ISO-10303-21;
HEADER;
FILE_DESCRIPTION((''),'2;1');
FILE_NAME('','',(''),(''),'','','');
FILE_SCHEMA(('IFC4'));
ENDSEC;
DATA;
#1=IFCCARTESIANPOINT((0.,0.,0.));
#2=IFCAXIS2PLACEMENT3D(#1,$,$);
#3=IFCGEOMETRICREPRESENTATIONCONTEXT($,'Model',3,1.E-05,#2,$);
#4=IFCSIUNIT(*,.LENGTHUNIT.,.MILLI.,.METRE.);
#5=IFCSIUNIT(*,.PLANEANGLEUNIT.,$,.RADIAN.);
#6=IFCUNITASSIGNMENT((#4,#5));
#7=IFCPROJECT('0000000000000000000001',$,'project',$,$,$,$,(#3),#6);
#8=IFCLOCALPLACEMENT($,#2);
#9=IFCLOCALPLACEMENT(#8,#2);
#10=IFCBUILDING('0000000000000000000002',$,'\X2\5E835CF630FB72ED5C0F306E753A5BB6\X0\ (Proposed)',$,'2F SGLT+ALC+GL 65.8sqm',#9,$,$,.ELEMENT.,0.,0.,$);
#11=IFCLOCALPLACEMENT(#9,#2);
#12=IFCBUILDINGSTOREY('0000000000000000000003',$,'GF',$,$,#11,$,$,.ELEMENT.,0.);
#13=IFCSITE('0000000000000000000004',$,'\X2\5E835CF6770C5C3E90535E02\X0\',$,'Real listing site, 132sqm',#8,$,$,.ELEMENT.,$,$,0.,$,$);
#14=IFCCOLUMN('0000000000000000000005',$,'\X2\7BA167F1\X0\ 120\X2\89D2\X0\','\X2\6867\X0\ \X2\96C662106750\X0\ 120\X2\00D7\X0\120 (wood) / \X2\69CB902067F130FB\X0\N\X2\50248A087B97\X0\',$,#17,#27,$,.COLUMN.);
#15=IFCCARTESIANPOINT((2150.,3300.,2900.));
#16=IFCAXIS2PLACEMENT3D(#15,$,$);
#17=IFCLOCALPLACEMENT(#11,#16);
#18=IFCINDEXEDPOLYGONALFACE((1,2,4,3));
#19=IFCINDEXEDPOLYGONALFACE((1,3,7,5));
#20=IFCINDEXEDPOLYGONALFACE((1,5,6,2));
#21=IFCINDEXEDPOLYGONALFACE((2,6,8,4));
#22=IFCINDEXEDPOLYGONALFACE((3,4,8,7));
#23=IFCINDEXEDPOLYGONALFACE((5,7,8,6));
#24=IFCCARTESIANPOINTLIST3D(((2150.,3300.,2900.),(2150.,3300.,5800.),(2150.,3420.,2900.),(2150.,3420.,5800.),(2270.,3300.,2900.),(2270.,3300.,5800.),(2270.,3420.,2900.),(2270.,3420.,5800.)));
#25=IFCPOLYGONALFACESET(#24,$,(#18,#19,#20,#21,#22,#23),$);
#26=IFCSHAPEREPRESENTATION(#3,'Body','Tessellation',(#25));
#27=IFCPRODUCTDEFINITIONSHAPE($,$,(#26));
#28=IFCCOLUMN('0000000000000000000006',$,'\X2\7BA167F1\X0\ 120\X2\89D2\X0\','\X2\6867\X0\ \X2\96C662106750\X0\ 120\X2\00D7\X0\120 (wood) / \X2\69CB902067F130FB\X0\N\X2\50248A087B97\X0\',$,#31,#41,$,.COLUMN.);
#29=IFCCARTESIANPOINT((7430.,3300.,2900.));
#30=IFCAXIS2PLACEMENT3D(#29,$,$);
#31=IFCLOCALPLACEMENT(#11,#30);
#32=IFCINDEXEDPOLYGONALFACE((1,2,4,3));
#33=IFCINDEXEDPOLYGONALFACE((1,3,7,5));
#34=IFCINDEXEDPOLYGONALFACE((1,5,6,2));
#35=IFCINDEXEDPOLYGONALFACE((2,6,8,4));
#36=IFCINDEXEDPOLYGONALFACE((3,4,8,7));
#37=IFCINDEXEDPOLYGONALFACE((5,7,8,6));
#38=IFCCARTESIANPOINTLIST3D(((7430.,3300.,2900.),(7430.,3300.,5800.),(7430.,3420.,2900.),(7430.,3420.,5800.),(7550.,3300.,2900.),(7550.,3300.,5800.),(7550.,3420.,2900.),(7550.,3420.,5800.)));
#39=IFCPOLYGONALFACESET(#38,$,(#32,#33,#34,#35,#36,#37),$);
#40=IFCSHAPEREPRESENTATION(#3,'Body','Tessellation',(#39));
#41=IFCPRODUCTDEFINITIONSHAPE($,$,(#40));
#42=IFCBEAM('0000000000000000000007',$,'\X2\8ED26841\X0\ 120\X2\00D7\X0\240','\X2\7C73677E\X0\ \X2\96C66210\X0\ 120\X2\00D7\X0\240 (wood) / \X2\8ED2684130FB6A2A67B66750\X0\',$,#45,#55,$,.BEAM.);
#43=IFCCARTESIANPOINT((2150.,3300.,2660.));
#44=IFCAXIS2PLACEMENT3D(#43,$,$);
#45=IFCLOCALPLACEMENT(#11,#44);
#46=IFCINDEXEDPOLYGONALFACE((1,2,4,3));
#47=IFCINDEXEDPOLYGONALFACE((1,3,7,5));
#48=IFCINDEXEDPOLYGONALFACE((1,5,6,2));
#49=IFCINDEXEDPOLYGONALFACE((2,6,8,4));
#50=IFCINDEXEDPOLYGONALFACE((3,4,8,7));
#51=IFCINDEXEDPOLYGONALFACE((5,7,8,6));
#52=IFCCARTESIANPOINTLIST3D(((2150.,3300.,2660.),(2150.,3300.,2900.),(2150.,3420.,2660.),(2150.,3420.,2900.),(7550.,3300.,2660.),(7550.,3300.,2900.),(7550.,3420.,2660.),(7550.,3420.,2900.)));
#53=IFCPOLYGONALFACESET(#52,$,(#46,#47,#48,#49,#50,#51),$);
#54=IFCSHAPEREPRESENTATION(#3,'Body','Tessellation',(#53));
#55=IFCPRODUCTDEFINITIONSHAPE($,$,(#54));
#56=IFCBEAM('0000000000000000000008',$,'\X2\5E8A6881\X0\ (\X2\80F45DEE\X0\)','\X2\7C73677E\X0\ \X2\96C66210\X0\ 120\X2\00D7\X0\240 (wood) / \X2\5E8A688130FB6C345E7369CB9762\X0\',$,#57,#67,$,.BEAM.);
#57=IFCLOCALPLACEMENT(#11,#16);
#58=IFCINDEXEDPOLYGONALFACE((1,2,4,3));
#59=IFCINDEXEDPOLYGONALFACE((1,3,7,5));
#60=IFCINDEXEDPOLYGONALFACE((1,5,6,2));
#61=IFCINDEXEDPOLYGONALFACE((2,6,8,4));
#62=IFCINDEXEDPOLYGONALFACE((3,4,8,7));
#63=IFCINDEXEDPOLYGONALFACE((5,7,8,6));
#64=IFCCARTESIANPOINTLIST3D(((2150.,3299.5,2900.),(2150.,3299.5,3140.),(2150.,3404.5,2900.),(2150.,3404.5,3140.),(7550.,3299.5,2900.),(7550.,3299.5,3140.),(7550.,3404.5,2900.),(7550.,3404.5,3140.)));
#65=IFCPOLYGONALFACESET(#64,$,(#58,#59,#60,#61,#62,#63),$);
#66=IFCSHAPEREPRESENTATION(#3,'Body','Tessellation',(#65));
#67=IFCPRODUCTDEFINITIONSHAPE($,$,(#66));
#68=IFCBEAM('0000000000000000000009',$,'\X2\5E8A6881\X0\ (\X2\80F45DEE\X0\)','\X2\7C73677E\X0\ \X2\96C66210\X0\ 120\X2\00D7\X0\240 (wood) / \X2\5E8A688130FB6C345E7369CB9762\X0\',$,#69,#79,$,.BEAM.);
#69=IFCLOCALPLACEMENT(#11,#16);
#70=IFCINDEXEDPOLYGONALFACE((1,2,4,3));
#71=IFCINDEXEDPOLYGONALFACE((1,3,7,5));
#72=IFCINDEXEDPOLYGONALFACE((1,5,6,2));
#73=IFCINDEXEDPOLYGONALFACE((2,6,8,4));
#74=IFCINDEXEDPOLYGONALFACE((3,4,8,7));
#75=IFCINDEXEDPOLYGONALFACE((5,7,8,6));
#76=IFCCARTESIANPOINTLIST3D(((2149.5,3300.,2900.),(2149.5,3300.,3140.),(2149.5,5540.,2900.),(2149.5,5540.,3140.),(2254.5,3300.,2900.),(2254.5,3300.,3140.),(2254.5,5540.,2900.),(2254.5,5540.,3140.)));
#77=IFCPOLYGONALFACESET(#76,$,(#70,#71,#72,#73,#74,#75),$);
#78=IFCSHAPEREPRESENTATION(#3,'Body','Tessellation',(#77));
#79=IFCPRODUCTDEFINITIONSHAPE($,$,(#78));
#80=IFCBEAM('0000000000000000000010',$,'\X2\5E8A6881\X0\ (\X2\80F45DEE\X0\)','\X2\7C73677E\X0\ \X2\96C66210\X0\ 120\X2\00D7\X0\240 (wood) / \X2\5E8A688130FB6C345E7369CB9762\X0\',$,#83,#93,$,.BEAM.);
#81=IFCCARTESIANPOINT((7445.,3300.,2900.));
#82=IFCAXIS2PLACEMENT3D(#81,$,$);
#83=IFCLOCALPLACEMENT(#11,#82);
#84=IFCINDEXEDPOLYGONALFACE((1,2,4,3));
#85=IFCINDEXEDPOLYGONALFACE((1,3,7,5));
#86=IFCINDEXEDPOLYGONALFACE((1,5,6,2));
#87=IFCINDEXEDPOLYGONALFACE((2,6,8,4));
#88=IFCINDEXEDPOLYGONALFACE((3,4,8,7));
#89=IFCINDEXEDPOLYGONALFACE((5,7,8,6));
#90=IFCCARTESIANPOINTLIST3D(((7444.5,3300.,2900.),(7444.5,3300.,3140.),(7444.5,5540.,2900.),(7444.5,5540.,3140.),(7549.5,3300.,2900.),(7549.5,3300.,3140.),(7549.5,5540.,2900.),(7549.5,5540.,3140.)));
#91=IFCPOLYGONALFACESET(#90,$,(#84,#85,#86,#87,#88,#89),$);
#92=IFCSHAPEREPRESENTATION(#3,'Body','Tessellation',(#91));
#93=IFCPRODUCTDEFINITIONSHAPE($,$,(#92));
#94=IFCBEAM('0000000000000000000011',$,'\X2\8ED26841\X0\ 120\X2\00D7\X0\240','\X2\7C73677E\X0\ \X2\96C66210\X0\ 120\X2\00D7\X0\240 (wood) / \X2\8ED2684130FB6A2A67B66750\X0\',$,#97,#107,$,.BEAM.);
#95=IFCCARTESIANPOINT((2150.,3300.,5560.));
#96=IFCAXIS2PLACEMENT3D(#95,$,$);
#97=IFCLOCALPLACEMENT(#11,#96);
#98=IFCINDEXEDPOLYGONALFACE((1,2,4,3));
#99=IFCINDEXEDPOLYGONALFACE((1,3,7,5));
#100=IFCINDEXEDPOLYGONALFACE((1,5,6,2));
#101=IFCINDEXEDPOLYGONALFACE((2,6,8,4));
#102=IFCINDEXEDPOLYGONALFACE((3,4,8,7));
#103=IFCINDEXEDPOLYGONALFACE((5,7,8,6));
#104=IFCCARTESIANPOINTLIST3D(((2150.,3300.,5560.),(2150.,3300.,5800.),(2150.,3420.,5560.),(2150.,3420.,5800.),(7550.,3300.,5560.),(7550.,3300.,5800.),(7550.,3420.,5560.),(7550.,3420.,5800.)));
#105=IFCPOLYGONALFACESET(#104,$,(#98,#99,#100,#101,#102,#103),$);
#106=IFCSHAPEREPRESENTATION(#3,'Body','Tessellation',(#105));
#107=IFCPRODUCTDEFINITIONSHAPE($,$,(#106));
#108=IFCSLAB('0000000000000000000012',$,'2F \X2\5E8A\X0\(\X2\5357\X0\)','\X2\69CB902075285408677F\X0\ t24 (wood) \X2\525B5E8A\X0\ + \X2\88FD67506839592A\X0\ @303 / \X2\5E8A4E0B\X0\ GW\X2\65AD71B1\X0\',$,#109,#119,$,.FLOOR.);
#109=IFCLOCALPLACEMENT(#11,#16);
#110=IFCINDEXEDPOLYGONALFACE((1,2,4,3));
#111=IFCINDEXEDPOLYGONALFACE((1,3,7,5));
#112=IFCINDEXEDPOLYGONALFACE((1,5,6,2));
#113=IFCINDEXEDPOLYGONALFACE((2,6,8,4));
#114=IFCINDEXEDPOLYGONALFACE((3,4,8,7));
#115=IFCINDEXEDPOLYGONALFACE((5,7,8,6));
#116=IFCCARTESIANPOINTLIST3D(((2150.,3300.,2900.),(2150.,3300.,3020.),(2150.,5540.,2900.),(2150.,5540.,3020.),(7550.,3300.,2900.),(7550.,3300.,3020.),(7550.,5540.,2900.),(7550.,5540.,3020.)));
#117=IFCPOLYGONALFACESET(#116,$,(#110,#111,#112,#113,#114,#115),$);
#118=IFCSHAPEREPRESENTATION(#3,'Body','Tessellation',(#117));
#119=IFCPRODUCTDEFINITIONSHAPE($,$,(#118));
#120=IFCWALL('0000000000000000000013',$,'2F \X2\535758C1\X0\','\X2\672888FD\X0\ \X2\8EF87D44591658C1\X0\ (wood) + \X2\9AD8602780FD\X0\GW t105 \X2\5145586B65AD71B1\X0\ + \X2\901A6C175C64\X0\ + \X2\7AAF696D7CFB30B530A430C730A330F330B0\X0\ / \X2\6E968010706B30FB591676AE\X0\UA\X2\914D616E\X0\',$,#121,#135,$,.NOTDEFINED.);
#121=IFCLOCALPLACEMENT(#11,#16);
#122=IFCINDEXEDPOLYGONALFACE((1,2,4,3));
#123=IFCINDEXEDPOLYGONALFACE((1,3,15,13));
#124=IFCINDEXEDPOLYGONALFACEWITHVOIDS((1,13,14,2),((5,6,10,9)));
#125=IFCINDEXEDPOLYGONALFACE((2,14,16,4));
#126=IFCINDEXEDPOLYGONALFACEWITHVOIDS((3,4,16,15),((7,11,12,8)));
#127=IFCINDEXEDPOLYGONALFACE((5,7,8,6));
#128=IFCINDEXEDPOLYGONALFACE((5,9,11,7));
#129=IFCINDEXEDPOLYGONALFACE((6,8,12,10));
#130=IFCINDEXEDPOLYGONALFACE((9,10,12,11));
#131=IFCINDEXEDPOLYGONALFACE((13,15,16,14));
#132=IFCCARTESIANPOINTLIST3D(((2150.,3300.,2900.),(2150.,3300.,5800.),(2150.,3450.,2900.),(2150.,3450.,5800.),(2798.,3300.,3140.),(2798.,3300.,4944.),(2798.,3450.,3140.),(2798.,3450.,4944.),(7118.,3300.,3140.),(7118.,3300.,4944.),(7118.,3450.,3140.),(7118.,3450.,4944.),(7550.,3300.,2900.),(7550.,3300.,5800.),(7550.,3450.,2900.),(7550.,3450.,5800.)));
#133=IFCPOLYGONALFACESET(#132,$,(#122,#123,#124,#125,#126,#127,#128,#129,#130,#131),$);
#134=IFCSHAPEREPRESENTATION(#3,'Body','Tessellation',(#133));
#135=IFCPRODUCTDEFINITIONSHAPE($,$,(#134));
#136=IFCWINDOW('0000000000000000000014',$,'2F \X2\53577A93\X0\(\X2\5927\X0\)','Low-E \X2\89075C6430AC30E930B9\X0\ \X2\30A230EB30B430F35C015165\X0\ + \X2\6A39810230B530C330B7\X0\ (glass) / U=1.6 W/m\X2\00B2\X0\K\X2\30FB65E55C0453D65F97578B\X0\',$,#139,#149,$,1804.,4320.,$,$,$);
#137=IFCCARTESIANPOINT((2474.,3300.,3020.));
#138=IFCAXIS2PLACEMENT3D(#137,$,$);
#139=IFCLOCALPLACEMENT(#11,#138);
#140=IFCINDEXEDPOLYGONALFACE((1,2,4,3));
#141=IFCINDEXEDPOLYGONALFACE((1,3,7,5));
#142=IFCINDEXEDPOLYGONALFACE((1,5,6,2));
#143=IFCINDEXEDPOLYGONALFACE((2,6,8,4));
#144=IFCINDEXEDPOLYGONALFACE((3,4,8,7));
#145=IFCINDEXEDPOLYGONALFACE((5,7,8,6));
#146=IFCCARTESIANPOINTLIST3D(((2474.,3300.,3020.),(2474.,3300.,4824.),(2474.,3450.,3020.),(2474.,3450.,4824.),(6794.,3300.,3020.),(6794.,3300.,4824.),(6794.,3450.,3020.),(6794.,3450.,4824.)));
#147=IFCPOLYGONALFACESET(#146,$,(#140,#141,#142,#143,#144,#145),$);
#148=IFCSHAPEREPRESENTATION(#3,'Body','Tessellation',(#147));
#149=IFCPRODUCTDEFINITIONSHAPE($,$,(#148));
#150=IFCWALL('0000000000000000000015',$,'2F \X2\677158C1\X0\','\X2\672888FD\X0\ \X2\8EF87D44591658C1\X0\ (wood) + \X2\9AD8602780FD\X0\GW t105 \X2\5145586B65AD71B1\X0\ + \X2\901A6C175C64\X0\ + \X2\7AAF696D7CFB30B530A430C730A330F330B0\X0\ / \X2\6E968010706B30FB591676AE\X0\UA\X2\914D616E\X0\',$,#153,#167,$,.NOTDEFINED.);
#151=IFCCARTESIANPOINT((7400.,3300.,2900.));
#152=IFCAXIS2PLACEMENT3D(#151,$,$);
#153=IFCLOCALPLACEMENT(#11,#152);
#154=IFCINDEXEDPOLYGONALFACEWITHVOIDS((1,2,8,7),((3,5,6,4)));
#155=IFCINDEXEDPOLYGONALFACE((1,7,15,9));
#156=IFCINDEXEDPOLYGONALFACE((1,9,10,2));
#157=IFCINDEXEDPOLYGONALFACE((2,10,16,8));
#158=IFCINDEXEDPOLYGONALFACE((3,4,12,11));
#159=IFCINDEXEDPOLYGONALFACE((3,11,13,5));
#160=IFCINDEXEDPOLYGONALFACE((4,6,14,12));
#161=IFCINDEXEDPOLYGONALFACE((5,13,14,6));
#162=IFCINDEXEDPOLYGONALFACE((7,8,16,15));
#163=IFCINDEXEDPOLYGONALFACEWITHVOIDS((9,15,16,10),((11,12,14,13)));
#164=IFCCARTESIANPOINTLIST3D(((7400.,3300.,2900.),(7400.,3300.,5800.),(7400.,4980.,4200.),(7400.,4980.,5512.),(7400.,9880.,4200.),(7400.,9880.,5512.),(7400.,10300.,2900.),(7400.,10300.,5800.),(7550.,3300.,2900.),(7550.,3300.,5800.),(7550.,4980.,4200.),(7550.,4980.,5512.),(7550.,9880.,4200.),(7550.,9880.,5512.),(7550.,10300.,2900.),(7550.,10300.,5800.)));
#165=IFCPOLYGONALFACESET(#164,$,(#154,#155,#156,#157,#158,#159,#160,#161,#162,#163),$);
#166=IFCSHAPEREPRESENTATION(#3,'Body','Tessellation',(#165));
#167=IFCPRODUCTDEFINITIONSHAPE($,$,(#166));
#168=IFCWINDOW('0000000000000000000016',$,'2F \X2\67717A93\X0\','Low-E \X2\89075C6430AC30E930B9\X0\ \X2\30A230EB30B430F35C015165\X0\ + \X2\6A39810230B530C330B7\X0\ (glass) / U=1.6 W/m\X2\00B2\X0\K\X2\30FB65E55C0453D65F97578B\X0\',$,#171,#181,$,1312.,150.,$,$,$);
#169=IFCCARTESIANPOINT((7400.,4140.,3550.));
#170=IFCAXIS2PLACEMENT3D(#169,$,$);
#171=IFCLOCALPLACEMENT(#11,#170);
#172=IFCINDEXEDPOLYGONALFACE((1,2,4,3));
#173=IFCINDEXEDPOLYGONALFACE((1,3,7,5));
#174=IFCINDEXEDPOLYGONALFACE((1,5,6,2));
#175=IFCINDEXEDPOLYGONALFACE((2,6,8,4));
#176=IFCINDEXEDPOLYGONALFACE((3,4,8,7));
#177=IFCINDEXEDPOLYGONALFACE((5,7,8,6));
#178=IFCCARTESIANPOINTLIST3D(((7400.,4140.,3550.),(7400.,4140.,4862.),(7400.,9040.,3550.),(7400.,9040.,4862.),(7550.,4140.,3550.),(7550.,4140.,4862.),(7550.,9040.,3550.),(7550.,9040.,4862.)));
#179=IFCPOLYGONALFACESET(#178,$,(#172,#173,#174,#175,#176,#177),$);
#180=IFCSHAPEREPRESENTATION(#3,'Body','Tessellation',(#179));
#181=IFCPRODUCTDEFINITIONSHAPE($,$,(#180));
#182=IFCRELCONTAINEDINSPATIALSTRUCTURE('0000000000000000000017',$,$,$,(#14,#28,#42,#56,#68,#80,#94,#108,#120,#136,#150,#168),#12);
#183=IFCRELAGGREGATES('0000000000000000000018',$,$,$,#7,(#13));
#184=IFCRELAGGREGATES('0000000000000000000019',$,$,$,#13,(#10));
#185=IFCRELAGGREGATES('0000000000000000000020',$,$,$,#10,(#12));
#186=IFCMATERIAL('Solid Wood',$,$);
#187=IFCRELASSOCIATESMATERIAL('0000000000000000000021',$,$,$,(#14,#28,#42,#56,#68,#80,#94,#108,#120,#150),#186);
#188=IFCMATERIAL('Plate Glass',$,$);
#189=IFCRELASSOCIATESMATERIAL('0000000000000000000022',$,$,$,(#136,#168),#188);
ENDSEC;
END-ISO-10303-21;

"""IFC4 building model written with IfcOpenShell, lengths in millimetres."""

from ifc_helpers import new_model, si_unit, frame, frame_2d, origin, place, context, project, spatial, rectangle, extrude, material, element, fill, save


model = new_model("IFC4")

# Units and contexts
model_context = context("Model", 3, precision=1e-05, world=origin())
ifc_project = project(units=[si_unit("LENGTHUNIT", "METRE", prefix="MILLI"), si_unit("PLANEANGLEUNIT", "RADIAN")], contexts=[model_context])

# Site, building, storey
site_placement = place(None, origin())
site = spatial("IfcSite", under=ifc_project, at=site_placement, Name="広島県尾道市", ObjectType="Real listing site, 132sqm", CompositionType="ELEMENT", RefElevation=0.0)
building_placement = place(site_placement, origin())
building = spatial("IfcBuilding", under=site, at=building_placement, Name="広島・狭小の町家 (Proposed)", ObjectType="2F SGLT+ALC+GL 65.8sqm", CompositionType="ELEMENT", ElevationOfRefHeight=0.0, ElevationOfTerrain=0.0)
storey_placement = place(building_placement, origin())
storey = spatial("IfcBuildingStorey", under=building, at=storey_placement, Name="GF", CompositionType="ELEMENT", Elevation=0.0)

# Columns
ifc_material_1 = material(Name="Solid Wood")
column_1_placement = place(storey_placement, frame((2150.0, 3300.0, 2900.0)))
element("IfcColumn", 1, at=column_1_placement, inside=storey, material=ifc_material_1, Name="管柱 120角", Description="桧 集成材 120×120 (wood) / 構造柱・N値計算", PredefinedType="COLUMN", context=model_context, shape_type="SweptSolid", body=[
    extrude(rectangle(XDim=120.0, YDim=120.0, at=frame_2d((60.0, 60.0))), frame((2150.0, 3300.0, 2900.0)), (0.0, 0.0, 1.0), 2900.0),
])
column_2_placement = place(storey_placement, frame((7430.0, 3300.0, 2900.0)))
element("IfcColumn", 2, at=column_2_placement, inside=storey, material=ifc_material_1, Name="管柱 120角", Description="桧 集成材 120×120 (wood) / 構造柱・N値計算", PredefinedType="COLUMN", context=model_context, shape_type="SweptSolid", body=[
    extrude(rectangle(XDim=120.0, YDim=120.0, at=frame_2d((60.0, 60.0))), frame((7430.0, 3300.0, 2900.0)), (0.0, 0.0, 1.0), 2900.0),
])

# Beams
beam_1_placement = place(storey_placement, frame((2150.0, 3300.0, 2660.0)))
element("IfcBeam", 3, at=beam_1_placement, inside=storey, material=ifc_material_1, Name="軒桁 120×240", Description="米松 集成 120×240 (wood) / 軒桁・横架材", PredefinedType="BEAM", context=model_context, shape_type="SweptSolid", body=[
    extrude(rectangle(XDim=5400.0, YDim=120.0, at=frame_2d((2700.0, 60.0))), frame((2150.0, 3300.0, 2660.0)), (0.0, 0.0, 1.0), 240.0),
])
beam_2_placement = place(storey_placement, frame((2150.0, 3300.0, 2900.0)))
element("IfcBeam", 4, at=beam_2_placement, inside=storey, material=ifc_material_1, Name="床梁 (胴差)", Description="米松 集成 120×240 (wood) / 床梁・水平構面", PredefinedType="BEAM", context=model_context, shape_type="SweptSolid", body=[
    extrude(rectangle(XDim=5400.0, YDim=105.0, at=frame_2d((2700.0, 52.0))), frame((2150.0, 3300.0, 2900.0)), (0.0, 0.0, 1.0), 240.0),
])
beam_3_placement = place(storey_placement, frame((2150.0, 3300.0, 2900.0)))
element("IfcBeam", 5, at=beam_3_placement, inside=storey, material=ifc_material_1, Name="床梁 (胴差)", Description="米松 集成 120×240 (wood) / 床梁・水平構面", PredefinedType="BEAM", context=model_context, shape_type="SweptSolid", body=[
    extrude(rectangle(XDim=105.0, YDim=2240.0, at=frame_2d((52.0, 1120.0))), frame((2150.0, 3300.0, 2900.0)), (0.0, 0.0, 1.0), 240.0),
])
beam_4_placement = place(storey_placement, frame((7445.0, 3300.0, 2900.0)))
element("IfcBeam", 6, at=beam_4_placement, inside=storey, material=ifc_material_1, Name="床梁 (胴差)", Description="米松 集成 120×240 (wood) / 床梁・水平構面", PredefinedType="BEAM", context=model_context, shape_type="SweptSolid", body=[
    extrude(rectangle(XDim=105.0, YDim=2240.0, at=frame_2d((52.0, 1120.0))), frame((7445.0, 3300.0, 2900.0)), (0.0, 0.0, 1.0), 240.0),
])
beam_5_placement = place(storey_placement, frame((2150.0, 3300.0, 5560.0)))
element("IfcBeam", 7, at=beam_5_placement, inside=storey, material=ifc_material_1, Name="軒桁 120×240", Description="米松 集成 120×240 (wood) / 軒桁・横架材", PredefinedType="BEAM", context=model_context, shape_type="SweptSolid", body=[
    extrude(rectangle(XDim=5400.0, YDim=120.0, at=frame_2d((2700.0, 60.0))), frame((2150.0, 3300.0, 5560.0)), (0.0, 0.0, 1.0), 240.0),
])

# Slab
slab_placement = place(storey_placement, frame((2150.0, 3300.0, 2900.0)))
element("IfcSlab", 8, at=slab_placement, inside=storey, material=ifc_material_1, Name="2F 床(南)", Description="構造用合板 t24 (wood) 剛床 + 製材根太 @303 / 床下 GW断熱", PredefinedType="FLOOR", context=model_context, shape_type="SweptSolid", body=[
    extrude(rectangle(XDim=5400.0, YDim=2240.0, at=frame_2d((2700.0, 1120.0))), frame((2150.0, 3300.0, 2900.0)), (0.0, 0.0, 1.0), 120.0),
])

# Walls, openings, windows
wall_1_placement = place(storey_placement, frame((2150.0, 3300.0, 2900.0)))
wall_1 = element("IfcWall", 9, at=wall_1_placement, inside=storey, material=ifc_material_1, Name="2F 南壁", Description="木製 軸組外壁 (wood) + 高性能GW t105 充填断熱 + 通気層 + 窯業系サイディング / 準耐火・外皮UA配慮", PredefinedType="NOTDEFINED", context=model_context, shape_type="SweptSolid", body=[
    extrude(rectangle(XDim=5400.0, YDim=150.0, at=frame_2d((2700.0, 75.0))), frame((2150.0, 3300.0, 2900.0)), (0.0, 0.0, 1.0), 2900.0),
])
opening_1_placement = place(storey_placement, frame((2474.0, 3300.0, 3020.0)))
opening_1 = element("IfcOpeningElement", 10, at=opening_1_placement, cuts=wall_1, PredefinedType="NOTDEFINED", context=model_context, shape_type="SweptSolid", body=[
    extrude(rectangle(XDim=4320.0, YDim=150.0, at=frame_2d((2160.0, 75.0))), frame((2474.0, 3300.0, 3020.0)), (0.0, 0.0, 1.0), 1804.0),
])
ifc_material_2 = material(Name="Plate Glass")
window_1_placement = place(storey_placement, frame((2474.0, 3300.0, 3020.0)))
window_1 = element("IfcWindow", 11, at=window_1_placement, inside=storey, material=ifc_material_2, Name="2F 南窓(大)", Description="Low-E 複層ガラス アルゴン封入 + 樹脂サッシ (glass) / U=1.6 W/m²K・日射取得型", OverallHeight=1804.0, OverallWidth=4320.0, context=model_context, shape_type="SweptSolid", body=[
    extrude(rectangle(XDim=4320.0, YDim=150.0, at=frame_2d((2160.0, 75.0))), frame((2474.0, 3300.0, 3020.0)), (0.0, 0.0, 1.0), 1804.0),
])
fill(opening_1, window_1)
wall_2_placement = place(storey_placement, frame((7400.0, 3300.0, 2900.0)))
wall_2 = element("IfcWall", 12, at=wall_2_placement, inside=storey, material=ifc_material_1, Name="2F 東壁", Description="木製 軸組外壁 (wood) + 高性能GW t105 充填断熱 + 通気層 + 窯業系サイディング / 準耐火・外皮UA配慮", PredefinedType="NOTDEFINED", context=model_context, shape_type="SweptSolid", body=[
    extrude(rectangle(XDim=150.0, YDim=7000.0, at=frame_2d((75.0, 3500.0))), frame((7400.0, 3300.0, 2900.0)), (0.0, 0.0, 1.0), 2900.0),
])
opening_2_placement = place(storey_placement, frame((7400.0, 4140.0, 3550.0)))
opening_2 = element("IfcOpeningElement", 13, at=opening_2_placement, cuts=wall_2, PredefinedType="NOTDEFINED", context=model_context, shape_type="SweptSolid", body=[
    extrude(rectangle(XDim=150.0, YDim=4900.0, at=frame_2d((75.0, 2450.0))), frame((7400.0, 4140.0, 3550.0)), (0.0, 0.0, 1.0), 1312.0),
])
window_2_placement = place(storey_placement, frame((7400.0, 4140.0, 3550.0)))
window_2 = element("IfcWindow", 14, at=window_2_placement, inside=storey, material=ifc_material_2, Name="2F 東窓", Description="Low-E 複層ガラス アルゴン封入 + 樹脂サッシ (glass) / U=1.6 W/m²K・日射取得型", OverallHeight=1312.0, OverallWidth=150.0, context=model_context, shape_type="SweptSolid", body=[
    extrude(rectangle(XDim=150.0, YDim=4900.0, at=frame_2d((75.0, 2450.0))), frame((7400.0, 4140.0, 3550.0)), (0.0, 0.0, 1.0), 1312.0),
])
fill(opening_2, window_2)

save(model, "model.ifc")
